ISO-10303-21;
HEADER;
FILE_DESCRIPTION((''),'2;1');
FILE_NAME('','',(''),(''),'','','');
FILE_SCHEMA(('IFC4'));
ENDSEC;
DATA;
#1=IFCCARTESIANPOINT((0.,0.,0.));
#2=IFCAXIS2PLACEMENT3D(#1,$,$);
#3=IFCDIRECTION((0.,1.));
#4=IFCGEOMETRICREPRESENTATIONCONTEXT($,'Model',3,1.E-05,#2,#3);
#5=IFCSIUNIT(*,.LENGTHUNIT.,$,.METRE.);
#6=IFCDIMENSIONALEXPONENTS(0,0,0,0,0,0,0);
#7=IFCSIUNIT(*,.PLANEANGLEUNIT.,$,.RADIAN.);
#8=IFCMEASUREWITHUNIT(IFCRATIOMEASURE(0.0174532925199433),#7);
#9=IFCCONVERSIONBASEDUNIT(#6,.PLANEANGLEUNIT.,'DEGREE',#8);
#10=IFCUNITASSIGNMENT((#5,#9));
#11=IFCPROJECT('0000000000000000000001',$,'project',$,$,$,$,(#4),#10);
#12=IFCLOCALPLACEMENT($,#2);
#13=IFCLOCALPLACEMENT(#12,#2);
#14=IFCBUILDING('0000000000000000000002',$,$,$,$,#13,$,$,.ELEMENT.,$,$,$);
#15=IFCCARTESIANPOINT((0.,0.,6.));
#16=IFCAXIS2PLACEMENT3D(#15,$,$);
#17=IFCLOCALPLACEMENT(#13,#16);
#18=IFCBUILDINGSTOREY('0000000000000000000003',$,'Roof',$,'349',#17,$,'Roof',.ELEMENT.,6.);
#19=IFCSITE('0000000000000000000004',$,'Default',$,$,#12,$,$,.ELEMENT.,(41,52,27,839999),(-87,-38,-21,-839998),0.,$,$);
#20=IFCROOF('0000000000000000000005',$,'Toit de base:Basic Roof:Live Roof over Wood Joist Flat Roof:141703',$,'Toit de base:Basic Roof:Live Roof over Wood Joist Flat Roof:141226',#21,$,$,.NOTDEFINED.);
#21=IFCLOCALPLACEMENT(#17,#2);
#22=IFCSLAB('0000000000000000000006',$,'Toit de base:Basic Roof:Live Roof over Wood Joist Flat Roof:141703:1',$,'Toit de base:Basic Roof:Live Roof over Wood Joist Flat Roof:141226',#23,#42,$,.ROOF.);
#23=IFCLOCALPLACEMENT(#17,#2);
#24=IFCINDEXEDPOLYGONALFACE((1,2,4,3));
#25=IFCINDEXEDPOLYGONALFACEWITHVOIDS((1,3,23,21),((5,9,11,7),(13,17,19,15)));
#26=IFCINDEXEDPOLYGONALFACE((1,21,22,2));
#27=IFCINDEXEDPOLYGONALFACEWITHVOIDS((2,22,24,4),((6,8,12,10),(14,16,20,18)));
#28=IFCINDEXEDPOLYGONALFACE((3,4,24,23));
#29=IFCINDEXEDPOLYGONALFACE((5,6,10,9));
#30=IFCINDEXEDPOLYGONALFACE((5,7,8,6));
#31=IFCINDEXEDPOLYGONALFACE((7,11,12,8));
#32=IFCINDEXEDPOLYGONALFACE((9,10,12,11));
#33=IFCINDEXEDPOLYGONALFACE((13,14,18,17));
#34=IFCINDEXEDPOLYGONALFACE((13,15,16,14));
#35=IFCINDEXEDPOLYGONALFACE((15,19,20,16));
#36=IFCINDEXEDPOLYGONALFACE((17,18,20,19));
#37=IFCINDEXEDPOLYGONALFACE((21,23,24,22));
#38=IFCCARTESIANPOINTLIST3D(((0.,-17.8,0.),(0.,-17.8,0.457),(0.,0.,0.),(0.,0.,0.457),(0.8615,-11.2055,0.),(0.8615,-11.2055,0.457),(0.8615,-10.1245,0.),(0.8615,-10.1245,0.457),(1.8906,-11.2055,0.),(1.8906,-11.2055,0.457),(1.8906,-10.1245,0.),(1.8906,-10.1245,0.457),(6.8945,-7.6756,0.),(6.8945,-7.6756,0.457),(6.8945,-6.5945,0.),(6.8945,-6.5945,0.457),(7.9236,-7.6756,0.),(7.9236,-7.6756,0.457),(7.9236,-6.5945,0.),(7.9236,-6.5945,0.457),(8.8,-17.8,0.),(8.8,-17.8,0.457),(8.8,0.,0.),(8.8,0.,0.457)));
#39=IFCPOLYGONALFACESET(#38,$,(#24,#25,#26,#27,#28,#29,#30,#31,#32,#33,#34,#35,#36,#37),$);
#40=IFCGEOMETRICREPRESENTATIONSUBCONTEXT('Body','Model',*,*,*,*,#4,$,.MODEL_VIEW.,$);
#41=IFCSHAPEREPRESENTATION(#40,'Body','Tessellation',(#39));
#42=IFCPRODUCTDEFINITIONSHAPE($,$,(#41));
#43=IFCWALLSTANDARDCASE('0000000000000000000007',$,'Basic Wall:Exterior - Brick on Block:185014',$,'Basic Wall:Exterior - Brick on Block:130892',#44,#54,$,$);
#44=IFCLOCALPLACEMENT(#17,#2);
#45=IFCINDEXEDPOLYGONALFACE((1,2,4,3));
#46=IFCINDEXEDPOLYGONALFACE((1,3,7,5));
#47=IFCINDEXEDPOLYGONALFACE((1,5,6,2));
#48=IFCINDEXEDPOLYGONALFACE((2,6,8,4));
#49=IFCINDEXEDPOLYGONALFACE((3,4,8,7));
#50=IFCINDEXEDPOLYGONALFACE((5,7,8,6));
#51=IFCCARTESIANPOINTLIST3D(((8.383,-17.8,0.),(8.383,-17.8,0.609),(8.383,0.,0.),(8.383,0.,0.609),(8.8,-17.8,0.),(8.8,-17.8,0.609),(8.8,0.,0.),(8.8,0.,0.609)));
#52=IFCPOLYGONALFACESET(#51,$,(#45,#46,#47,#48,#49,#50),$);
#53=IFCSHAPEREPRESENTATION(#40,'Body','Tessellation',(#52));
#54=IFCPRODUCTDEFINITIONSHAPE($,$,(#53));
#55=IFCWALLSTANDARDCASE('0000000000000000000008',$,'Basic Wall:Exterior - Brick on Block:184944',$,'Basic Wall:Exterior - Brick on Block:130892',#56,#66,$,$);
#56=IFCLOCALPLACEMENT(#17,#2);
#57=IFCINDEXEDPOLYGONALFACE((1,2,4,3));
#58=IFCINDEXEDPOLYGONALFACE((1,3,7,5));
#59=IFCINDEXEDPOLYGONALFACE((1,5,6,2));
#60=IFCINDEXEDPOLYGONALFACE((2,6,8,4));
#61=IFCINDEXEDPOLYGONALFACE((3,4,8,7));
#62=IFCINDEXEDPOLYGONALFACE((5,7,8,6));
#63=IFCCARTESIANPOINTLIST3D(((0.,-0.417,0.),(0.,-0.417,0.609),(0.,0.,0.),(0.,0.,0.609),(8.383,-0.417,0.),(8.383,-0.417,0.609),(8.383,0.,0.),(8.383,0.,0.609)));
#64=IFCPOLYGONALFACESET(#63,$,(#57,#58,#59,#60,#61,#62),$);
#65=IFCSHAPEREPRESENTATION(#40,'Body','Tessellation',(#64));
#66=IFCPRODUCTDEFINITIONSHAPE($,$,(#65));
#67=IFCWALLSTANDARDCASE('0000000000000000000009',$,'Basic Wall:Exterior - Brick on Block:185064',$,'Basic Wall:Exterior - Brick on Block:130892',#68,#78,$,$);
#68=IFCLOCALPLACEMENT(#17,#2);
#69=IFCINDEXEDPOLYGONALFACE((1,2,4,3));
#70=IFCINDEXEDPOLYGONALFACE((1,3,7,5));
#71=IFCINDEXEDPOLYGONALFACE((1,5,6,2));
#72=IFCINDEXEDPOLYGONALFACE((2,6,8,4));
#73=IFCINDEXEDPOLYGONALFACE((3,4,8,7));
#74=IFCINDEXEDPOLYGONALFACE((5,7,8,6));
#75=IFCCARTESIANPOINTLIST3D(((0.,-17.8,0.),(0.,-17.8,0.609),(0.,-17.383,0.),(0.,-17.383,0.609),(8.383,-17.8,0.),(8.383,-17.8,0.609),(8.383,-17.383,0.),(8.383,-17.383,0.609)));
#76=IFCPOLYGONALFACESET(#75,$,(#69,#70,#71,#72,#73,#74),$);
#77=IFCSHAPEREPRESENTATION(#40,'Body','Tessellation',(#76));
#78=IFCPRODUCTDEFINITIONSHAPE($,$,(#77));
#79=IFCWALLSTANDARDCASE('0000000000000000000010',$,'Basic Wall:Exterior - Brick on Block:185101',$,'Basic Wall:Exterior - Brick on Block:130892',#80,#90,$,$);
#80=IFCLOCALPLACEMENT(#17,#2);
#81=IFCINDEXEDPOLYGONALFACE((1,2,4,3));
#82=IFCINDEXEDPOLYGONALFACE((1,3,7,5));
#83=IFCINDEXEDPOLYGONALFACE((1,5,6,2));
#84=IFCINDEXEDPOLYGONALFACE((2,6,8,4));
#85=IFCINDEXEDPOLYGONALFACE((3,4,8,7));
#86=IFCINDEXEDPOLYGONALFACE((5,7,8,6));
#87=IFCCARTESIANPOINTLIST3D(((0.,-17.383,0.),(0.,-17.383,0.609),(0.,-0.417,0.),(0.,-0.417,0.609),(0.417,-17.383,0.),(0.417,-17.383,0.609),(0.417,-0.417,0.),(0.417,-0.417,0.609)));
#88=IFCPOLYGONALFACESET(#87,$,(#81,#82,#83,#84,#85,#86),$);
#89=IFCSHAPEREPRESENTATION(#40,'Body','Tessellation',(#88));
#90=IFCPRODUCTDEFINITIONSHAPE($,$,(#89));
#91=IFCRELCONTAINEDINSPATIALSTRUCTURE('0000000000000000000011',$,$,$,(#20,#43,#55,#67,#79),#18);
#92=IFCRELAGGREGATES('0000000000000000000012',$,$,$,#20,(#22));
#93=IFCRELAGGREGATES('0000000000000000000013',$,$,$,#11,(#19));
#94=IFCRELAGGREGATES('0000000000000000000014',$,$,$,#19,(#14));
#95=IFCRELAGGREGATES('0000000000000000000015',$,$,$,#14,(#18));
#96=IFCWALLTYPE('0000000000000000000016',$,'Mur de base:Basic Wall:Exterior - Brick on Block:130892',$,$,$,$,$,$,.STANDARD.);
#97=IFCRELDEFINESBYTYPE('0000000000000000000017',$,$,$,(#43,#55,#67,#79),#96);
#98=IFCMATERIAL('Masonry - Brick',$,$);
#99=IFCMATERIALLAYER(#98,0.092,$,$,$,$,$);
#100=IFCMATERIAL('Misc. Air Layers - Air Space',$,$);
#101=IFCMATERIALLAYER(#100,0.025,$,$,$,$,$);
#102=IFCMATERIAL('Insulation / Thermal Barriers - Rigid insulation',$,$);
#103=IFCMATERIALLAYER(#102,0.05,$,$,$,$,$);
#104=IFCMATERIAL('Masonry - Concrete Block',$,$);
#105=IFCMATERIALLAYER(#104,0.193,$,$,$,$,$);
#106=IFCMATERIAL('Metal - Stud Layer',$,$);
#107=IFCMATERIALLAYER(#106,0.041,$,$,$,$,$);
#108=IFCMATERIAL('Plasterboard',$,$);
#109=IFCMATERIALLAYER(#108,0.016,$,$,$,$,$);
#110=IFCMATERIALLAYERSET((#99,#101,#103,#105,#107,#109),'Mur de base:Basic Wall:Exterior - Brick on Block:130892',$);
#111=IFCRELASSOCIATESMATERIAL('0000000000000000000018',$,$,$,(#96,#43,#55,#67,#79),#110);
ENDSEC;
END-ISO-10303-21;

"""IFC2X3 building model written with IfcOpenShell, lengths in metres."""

from ifc_helpers import new_model, entity, si_unit, converted_unit, direction, frame, frame_2d, origin, origin_2d_with_axis, place, context, subcontext, project, spatial, rectangle, extrude, material, layer, layer_set, layer_usage, type_object, element, aggregate, save


model = new_model("IFC2X3")

# Units and contexts
model_context = context("Model", 3, precision=1e-05, world=origin(), true_north=direction((0.0, 1.0)))
body_context = subcontext(model_context, "Body", "Model", "MODEL_VIEW")
ifc_project = project(units=[si_unit("LENGTHUNIT", "METRE"), converted_unit("PLANEANGLEUNIT", "DEGREE", entity("IfcRatioMeasure", 0.0174532925199433), si_unit("PLANEANGLEUNIT", "RADIAN"), dimensions=[0, 0, 0, 0, 0, 0, 0])], contexts=[model_context])

# Site, building, storey
site_placement = place(None, origin())
site = spatial("IfcSite", under=ifc_project, at=site_placement, Name="Default", CompositionType="ELEMENT", RefLatitude=(41, 52, 27, 839999), RefLongitude=(-87, -38, -21, -839998), RefElevation=0.0)
building_placement = place(site_placement, origin())
building = spatial("IfcBuilding", under=site, at=building_placement, CompositionType="ELEMENT")
storey_placement = place(building_placement, frame((0.0, 0.0, 6.0)))
storey = spatial("IfcBuildingStorey", under=building, at=storey_placement, Name="Roof", ObjectType="349", LongName="Roof", CompositionType="ELEMENT", Elevation=6.0)

# Roof, slab, openings
roof_placement = place(storey_placement, origin())
roof = element("IfcRoof", 1, at=roof_placement, inside=storey, Name="Toit de base:Basic Roof:Live Roof over Wood Joist Flat Roof:141703", ObjectType="Toit de base:Basic Roof:Live Roof over Wood Joist Flat Roof:141226", ShapeType="NOTDEFINED")
slab_placement = place(storey_placement, origin())
slab = element("IfcSlab", 2, at=slab_placement, Name="Toit de base:Basic Roof:Live Roof over Wood Joist Flat Roof:141703:1", ObjectType="Toit de base:Basic Roof:Live Roof over Wood Joist Flat Roof:141226", PredefinedType="ROOF", context=body_context, shape_type="SweptSolid", body=[
    extrude(rectangle(XDim=17.8, YDim=8.8, at=origin_2d_with_axis()), frame((4.4, -8.9, 0.0), z_axis=(0.0, 0.0, 1.0), x_axis=(0.0, 1.0, 0.0)), (0.0, 0.0, 1.0), 0.457),
])
opening_1_placement = place(storey_placement, origin())
element("IfcOpeningElement", 3, at=opening_1_placement, cuts=slab, ObjectType="Opening", context=body_context, shape_type="SweptSolid", body=[
    extrude(rectangle(XDim=1.0291, YDim=1.0811, at=frame_2d((0.0, 0.0), x_axis=(1.0, 0.0))), frame((1.376, -10.665, 0.0)), (0.0, 0.0, 1.0), 0.457),
])
opening_2_placement = place(storey_placement, origin())
element("IfcOpeningElement", 4, at=opening_2_placement, cuts=slab, ObjectType="Opening", context=body_context, shape_type="SweptSolid", body=[
    extrude(rectangle(XDim=1.0291, YDim=1.0811, at=origin_2d_with_axis()), frame((7.409, -7.135, 0.0)), (0.0, 0.0, 1.0), 0.457),
])
aggregate(roof, [slab])

# Walls
ifc_material_1 = material(Name="Masonry - Brick")
ifc_layer_1 = layer(ifc_material_1, 0.092)
ifc_material_2 = material(Name="Misc. Air Layers - Air Space")
ifc_layer_2 = layer(ifc_material_2, 0.025)
ifc_material_3 = material(Name="Insulation / Thermal Barriers - Rigid insulation")
ifc_layer_3 = layer(ifc_material_3, 0.05)
ifc_material_4 = material(Name="Masonry - Concrete Block")
ifc_layer_4 = layer(ifc_material_4, 0.193)
ifc_material_5 = material(Name="Metal - Stud Layer")
ifc_layer_5 = layer(ifc_material_5, 0.041)
ifc_material_6 = material(Name="Plasterboard")
ifc_layer_6 = layer(ifc_material_6, 0.016)
ifc_layer_set = layer_set([ifc_layer_1, ifc_layer_2, ifc_layer_3, ifc_layer_4, ifc_layer_5, ifc_layer_6], Name="Mur de base:Basic Wall:Exterior - Brick on Block:130892")
ifc_layer_usage_1 = layer_usage(ifc_layer_set, "AXIS2", "NEGATIVE", 0.2085)
wall_type = type_object("IfcWallType", Name="Mur de base:Basic Wall:Exterior - Brick on Block:130892", PredefinedType="STANDARD", material=ifc_layer_set)
wall_1_placement = place(storey_placement, frame((8.5915, 0.0, 0.0), z_axis=(0.0, 0.0, 1.0), x_axis=(0.0, -1.0, 0.0)))
element("IfcWallStandardCase", 5, at=wall_1_placement, inside=storey, type_object=wall_type, material=ifc_layer_usage_1, Name="Basic Wall:Exterior - Brick on Block:185014", ObjectType="Basic Wall:Exterior - Brick on Block:130892", context=body_context, shape_type="SweptSolid", body=[
    extrude(rectangle(XDim=17.8, YDim=0.417, at=frame_2d((8.9, 0.0), x_axis=(-1.0, 0.0))), origin(), (0.0, 0.0, 1.0), 0.609),
])
ifc_layer_usage_2 = layer_usage(ifc_layer_set, "AXIS2", "NEGATIVE", 0.2085)
wall_2_placement = place(storey_placement, frame((0.0, -0.2085, 0.0)))
element("IfcWallStandardCase", 6, at=wall_2_placement, inside=storey, type_object=wall_type, material=ifc_layer_usage_2, Name="Basic Wall:Exterior - Brick on Block:184944", ObjectType="Basic Wall:Exterior - Brick on Block:130892", context=body_context, shape_type="SweptSolid", body=[
    extrude(rectangle(XDim=8.383, YDim=0.417, at=frame_2d((4.1915, 0.0), x_axis=(-1.0, 0.0))), origin(), (0.0, 0.0, 1.0), 0.609),
])
ifc_layer_usage_3 = layer_usage(ifc_layer_set, "AXIS2", "NEGATIVE", 0.2085)
wall_3_placement = place(storey_placement, frame((8.383, -17.5915, 0.0), z_axis=(0.0, 0.0, 1.0), x_axis=(-1.0, 0.0, 0.0)))
element("IfcWallStandardCase", 7, at=wall_3_placement, inside=storey, type_object=wall_type, material=ifc_layer_usage_3, Name="Basic Wall:Exterior - Brick on Block:185064", ObjectType="Basic Wall:Exterior - Brick on Block:130892", context=body_context, shape_type="SweptSolid", body=[
    extrude(rectangle(XDim=8.383, YDim=0.417, at=frame_2d((4.1915, 0.0), x_axis=(-1.0, 0.0))), origin(), (0.0, 0.0, 1.0), 0.609),
])
ifc_layer_usage_4 = layer_usage(ifc_layer_set, "AXIS2", "NEGATIVE", 0.2085)
wall_4_placement = place(storey_placement, frame((0.2085, -17.383, 0.0), z_axis=(0.0, 0.0, 1.0), x_axis=(0.0, 1.0, 0.0)))
element("IfcWallStandardCase", 8, at=wall_4_placement, inside=storey, type_object=wall_type, material=ifc_layer_usage_4, Name="Basic Wall:Exterior - Brick on Block:185101", ObjectType="Basic Wall:Exterior - Brick on Block:130892", context=body_context, shape_type="SweptSolid", body=[
    extrude(rectangle(XDim=16.966, YDim=0.417, at=frame_2d((8.483, 0.0), x_axis=(-1.0, 0.0))), origin(), (0.0, 0.0, 1.0), 0.609),
])

save(model, "model.ifc")
